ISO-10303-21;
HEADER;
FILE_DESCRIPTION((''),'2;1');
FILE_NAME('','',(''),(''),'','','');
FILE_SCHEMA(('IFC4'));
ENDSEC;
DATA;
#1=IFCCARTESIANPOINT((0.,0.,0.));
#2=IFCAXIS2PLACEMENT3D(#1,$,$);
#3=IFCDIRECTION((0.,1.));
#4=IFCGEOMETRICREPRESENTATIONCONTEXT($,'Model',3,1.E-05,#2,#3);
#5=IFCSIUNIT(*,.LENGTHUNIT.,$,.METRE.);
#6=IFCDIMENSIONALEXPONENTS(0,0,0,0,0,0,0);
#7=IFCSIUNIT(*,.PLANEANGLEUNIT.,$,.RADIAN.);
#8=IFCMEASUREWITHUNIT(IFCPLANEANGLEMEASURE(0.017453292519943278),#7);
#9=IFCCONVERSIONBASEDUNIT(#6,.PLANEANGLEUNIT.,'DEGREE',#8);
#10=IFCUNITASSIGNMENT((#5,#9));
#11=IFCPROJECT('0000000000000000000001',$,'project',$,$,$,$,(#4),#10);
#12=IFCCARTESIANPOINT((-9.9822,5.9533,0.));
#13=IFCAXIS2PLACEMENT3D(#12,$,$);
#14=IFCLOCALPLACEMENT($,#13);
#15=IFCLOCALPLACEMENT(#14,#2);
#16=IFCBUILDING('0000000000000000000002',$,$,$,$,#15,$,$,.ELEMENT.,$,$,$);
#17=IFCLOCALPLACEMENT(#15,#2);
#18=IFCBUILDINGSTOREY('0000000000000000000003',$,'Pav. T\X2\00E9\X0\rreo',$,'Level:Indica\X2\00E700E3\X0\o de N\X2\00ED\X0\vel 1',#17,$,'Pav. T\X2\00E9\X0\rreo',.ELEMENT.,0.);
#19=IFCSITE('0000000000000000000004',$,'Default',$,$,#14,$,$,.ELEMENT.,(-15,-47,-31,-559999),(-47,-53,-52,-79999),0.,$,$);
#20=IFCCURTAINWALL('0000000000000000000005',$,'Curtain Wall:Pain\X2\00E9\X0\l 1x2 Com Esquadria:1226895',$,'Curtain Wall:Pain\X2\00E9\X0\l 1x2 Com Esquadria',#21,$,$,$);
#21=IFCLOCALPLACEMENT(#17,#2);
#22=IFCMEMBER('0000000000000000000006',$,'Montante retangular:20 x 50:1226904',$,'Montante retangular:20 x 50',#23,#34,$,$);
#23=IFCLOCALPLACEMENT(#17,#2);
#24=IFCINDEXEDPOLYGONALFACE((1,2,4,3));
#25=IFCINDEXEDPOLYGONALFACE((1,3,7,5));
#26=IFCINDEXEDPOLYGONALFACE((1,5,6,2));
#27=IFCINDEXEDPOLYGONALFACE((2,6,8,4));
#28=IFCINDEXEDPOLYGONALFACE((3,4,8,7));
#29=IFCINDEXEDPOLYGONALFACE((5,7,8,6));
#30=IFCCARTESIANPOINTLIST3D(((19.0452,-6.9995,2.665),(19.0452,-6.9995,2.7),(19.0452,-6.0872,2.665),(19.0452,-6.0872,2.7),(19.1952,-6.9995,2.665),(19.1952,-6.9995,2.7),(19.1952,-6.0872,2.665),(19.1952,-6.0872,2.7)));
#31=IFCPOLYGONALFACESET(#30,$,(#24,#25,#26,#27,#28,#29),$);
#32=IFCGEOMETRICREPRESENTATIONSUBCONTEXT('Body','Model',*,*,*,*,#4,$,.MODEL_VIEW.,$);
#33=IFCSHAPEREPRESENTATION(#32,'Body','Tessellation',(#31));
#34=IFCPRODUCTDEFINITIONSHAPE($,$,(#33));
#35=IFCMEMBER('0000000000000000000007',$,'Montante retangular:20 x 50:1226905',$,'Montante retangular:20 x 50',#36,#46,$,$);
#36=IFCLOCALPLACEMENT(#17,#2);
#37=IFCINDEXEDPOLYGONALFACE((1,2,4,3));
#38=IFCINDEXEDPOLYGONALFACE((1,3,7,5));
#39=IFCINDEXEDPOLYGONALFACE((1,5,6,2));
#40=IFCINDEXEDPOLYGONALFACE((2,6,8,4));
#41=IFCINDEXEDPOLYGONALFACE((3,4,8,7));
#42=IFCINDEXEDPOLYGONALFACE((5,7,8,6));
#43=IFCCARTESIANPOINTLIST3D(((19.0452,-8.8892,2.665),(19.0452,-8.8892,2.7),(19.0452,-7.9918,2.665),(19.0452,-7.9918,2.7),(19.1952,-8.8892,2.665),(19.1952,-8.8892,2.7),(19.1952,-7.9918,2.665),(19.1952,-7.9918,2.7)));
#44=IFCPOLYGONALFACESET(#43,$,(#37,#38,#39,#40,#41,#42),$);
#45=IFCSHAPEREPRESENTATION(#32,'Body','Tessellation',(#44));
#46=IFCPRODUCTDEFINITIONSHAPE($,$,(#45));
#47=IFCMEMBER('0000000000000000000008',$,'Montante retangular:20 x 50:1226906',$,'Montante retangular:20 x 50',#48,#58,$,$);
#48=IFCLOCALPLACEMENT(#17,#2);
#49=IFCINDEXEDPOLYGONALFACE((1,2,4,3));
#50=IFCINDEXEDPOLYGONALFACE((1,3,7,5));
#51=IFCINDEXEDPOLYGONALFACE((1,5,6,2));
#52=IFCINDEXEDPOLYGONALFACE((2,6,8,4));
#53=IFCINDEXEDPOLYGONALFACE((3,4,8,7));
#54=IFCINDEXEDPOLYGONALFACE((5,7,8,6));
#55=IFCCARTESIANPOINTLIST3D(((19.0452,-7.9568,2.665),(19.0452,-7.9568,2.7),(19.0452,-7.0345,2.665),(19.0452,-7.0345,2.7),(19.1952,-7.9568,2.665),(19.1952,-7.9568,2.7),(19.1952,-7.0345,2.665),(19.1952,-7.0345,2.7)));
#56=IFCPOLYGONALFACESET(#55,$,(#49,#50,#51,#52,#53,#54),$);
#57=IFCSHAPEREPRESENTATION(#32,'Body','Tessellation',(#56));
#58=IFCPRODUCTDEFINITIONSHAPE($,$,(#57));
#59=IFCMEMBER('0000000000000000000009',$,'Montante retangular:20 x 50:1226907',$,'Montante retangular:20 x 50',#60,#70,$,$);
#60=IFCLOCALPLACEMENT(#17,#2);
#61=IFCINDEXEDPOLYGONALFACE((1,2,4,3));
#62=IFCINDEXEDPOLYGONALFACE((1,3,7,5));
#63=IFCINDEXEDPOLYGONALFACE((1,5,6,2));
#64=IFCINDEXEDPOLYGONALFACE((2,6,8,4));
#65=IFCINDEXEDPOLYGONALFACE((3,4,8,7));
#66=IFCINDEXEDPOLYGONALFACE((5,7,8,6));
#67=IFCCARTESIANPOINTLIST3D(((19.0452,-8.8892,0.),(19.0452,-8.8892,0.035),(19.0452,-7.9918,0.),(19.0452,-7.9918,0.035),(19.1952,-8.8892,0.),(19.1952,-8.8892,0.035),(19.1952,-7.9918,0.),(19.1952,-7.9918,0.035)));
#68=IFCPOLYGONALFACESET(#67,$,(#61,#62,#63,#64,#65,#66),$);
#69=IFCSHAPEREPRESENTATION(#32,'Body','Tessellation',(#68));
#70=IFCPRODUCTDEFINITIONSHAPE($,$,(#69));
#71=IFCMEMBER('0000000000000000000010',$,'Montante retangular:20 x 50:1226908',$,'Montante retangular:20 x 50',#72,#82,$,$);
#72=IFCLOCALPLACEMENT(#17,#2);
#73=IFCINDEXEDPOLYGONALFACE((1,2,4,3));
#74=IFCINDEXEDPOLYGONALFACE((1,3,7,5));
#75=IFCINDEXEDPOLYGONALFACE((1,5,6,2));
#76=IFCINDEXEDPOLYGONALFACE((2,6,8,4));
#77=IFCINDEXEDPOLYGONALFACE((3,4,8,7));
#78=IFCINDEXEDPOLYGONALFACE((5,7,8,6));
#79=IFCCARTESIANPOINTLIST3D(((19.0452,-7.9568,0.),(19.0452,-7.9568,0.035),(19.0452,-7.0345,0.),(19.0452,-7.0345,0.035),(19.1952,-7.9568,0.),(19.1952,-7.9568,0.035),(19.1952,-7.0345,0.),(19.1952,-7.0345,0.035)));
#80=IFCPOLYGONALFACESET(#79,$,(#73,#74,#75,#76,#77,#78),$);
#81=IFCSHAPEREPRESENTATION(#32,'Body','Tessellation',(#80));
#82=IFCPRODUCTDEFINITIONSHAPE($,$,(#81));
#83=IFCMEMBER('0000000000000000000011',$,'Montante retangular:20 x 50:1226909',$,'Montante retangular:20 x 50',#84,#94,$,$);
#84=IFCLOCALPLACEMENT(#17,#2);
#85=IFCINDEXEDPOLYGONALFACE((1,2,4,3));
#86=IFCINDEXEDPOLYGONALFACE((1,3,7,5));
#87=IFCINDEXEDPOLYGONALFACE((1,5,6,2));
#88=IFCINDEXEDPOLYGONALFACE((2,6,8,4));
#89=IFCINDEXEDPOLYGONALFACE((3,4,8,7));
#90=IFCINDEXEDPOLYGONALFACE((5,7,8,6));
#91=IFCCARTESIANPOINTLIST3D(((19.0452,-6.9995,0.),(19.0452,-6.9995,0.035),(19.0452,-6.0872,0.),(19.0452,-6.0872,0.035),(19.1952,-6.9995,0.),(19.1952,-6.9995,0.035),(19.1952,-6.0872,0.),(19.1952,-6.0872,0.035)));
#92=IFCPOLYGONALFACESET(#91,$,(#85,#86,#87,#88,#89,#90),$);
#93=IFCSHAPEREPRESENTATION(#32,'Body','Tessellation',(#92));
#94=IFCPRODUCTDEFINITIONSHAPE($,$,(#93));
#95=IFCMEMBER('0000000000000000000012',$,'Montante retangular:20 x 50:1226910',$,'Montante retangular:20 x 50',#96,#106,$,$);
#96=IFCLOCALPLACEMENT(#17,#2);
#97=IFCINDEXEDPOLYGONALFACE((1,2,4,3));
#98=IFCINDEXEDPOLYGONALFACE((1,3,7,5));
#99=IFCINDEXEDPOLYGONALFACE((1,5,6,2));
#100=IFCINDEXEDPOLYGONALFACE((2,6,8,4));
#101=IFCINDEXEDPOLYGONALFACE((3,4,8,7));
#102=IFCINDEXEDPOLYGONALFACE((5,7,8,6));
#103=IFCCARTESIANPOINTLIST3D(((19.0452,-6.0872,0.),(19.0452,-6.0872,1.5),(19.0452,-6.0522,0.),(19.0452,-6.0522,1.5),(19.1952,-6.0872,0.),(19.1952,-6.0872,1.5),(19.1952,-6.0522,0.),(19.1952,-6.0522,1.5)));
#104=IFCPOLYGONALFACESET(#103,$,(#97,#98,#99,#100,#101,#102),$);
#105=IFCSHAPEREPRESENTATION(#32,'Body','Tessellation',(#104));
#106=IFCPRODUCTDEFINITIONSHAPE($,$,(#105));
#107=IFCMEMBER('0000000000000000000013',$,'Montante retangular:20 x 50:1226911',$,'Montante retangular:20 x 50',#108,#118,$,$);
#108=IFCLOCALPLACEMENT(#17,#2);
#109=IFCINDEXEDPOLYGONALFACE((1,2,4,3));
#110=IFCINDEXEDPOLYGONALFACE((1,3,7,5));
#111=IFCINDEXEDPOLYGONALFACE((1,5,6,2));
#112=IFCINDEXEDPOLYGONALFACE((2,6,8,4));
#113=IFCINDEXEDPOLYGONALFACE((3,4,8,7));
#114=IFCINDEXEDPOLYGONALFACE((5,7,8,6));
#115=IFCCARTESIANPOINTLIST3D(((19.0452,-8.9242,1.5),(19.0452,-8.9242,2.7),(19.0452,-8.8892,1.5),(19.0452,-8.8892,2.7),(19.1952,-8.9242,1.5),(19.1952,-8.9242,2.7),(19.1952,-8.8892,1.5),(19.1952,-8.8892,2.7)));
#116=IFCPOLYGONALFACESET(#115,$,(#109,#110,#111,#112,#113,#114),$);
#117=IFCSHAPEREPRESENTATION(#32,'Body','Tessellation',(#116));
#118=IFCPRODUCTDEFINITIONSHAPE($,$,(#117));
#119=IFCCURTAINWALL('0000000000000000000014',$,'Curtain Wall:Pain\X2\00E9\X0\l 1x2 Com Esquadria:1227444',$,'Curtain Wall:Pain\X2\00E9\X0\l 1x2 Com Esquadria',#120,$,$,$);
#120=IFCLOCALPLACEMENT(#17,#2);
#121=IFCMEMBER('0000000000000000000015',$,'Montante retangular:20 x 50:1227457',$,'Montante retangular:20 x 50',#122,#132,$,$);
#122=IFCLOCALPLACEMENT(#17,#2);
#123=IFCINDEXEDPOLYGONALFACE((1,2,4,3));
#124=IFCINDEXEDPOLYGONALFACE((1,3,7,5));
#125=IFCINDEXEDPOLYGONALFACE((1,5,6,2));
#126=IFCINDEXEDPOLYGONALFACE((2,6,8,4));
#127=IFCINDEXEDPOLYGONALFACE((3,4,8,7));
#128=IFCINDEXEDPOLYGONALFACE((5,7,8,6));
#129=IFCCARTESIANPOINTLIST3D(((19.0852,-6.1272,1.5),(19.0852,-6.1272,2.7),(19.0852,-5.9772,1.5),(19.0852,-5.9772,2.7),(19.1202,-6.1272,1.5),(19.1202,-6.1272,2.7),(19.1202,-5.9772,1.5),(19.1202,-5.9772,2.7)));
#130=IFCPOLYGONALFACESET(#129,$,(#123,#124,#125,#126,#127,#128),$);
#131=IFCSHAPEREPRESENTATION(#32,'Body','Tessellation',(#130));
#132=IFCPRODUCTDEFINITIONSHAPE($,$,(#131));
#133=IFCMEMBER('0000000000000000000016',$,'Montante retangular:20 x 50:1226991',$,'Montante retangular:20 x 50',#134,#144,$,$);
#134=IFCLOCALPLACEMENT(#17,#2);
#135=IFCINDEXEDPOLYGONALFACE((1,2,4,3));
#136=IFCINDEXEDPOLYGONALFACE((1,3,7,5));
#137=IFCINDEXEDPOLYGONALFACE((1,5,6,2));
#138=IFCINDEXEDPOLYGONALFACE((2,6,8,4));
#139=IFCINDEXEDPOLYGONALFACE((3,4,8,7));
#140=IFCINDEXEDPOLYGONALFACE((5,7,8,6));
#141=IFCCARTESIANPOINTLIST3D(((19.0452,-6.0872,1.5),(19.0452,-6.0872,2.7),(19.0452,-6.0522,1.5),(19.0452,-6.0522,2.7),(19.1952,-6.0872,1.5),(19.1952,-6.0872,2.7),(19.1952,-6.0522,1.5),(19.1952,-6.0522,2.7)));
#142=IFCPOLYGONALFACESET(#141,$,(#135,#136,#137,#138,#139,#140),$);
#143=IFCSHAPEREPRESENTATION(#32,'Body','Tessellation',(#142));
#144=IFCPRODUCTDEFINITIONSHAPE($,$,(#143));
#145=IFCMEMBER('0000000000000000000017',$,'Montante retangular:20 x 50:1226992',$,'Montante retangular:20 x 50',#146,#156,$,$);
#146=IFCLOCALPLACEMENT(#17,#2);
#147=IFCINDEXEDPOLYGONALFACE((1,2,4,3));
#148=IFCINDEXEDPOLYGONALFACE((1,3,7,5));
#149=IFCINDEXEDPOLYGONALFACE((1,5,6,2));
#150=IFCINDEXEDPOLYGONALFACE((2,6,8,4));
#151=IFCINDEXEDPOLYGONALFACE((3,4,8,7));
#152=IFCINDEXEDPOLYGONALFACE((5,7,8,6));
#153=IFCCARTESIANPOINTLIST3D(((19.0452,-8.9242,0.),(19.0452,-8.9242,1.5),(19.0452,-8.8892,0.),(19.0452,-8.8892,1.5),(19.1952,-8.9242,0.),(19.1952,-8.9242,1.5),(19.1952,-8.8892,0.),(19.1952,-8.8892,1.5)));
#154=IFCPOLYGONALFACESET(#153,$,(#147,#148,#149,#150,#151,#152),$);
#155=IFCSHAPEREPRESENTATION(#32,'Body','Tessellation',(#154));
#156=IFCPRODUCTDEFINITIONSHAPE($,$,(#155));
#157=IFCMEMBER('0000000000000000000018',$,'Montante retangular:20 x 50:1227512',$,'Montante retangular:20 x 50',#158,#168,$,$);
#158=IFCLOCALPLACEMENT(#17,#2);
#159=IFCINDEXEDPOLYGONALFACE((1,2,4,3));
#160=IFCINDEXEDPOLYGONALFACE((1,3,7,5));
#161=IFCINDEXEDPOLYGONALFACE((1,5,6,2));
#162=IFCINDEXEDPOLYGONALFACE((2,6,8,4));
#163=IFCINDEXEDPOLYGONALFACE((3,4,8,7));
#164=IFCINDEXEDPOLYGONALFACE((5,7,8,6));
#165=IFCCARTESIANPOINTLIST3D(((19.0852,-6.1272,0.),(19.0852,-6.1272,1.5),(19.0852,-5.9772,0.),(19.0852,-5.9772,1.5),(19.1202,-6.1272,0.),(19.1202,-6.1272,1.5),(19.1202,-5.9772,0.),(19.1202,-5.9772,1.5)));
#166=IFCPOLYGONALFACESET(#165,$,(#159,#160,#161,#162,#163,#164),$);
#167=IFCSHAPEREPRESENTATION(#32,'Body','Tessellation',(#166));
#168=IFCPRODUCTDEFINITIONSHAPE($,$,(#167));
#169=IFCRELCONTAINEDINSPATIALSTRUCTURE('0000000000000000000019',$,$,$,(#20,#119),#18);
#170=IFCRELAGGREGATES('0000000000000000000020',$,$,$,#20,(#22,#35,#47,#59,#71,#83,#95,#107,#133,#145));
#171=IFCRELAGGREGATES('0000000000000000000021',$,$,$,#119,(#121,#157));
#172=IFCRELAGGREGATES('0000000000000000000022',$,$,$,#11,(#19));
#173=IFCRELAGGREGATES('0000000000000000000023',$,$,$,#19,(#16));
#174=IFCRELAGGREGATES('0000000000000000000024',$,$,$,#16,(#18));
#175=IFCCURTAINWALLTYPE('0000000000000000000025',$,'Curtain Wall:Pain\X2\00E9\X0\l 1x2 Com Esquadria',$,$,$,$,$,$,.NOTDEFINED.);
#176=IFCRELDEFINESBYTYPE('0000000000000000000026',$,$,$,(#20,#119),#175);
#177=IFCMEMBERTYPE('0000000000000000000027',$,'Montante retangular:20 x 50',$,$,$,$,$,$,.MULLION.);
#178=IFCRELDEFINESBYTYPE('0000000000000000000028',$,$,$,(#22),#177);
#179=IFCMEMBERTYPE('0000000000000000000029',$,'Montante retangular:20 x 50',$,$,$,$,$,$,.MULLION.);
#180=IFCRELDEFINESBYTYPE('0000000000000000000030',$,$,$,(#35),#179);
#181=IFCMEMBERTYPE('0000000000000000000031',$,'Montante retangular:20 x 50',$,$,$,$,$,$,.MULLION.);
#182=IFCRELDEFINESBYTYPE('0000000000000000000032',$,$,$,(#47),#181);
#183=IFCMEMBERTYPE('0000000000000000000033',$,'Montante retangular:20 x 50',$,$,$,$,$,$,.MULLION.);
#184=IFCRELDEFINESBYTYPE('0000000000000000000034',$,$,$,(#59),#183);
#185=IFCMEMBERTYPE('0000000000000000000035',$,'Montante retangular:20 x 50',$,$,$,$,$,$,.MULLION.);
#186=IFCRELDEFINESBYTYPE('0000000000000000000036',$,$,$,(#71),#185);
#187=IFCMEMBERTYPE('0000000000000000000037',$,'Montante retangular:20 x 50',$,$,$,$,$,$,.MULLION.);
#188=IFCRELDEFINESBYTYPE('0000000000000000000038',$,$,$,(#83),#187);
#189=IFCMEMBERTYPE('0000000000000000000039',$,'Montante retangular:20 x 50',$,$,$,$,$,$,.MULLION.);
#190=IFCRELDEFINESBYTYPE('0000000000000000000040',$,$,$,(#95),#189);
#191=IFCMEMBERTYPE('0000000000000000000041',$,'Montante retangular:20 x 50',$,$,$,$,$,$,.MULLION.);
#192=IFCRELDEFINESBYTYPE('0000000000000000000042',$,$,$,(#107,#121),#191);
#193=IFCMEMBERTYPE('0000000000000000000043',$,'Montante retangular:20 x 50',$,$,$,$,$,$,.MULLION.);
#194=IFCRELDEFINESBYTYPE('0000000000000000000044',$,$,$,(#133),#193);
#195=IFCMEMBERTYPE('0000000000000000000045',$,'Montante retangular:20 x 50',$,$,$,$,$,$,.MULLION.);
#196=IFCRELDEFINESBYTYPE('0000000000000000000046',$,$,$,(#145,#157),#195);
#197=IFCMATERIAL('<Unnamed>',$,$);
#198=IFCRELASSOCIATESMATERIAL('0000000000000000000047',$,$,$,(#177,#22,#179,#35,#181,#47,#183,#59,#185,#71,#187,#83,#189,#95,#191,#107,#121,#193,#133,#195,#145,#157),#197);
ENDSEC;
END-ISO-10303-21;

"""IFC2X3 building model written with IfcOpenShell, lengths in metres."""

from ifc_helpers import new_model, entity, si_unit, converted_unit, direction, frame, origin, origin_2d_with_axis, place, context, subcontext, project, spatial, rectangle, extrude, source, transform, mapped, material, type_object, type_shapes, element, aggregate, save


model = new_model("IFC2X3")

# Units and contexts
model_context = context("Model", 3, precision=1e-05, world=origin(), true_north=direction((0.0, 1.0)))
body_context = subcontext(model_context, "Body", "Model", "MODEL_VIEW")
ifc_project = project(units=[si_unit("LENGTHUNIT", "METRE"), converted_unit("PLANEANGLEUNIT", "DEGREE", entity("IfcPlaneAngleMeasure", 0.017453292519943278), si_unit("PLANEANGLEUNIT", "RADIAN"), dimensions=[0, 0, 0, 0, 0, 0, 0])], contexts=[model_context])

# Site, building, storey
site_placement = place(None, frame((-9.9822, 5.9533, 0.0)))
site = spatial("IfcSite", under=ifc_project, at=site_placement, Name="Default", CompositionType="ELEMENT", RefLatitude=(-15, -47, -31, -559999), RefLongitude=(-47, -53, -52, -79999), RefElevation=0.0)
building_placement = place(site_placement, origin())
building = spatial("IfcBuilding", under=site, at=building_placement, CompositionType="ELEMENT")
storey_placement = place(building_placement, origin())
storey = spatial("IfcBuildingStorey", under=building, at=storey_placement, Name="Pav. Térreo", ObjectType="Level:Indicação de Nível 1", LongName="Pav. Térreo", CompositionType="ELEMENT", Elevation=0.0)

# Curtain wall, members
curtain_wall_type = type_object("IfcCurtainWallType", Name="Curtain Wall:Painél 1x2 Com Esquadria", PredefinedType="NOTDEFINED")
curtain_wall_1_placement = place(storey_placement, origin())
curtain_wall_1 = element("IfcCurtainWall", 1, at=curtain_wall_1_placement, inside=storey, type_object=curtain_wall_type, Name="Curtain Wall:Painél 1x2 Com Esquadria:1226895", ObjectType="Curtain Wall:Painél 1x2 Com Esquadria")
ifc_material_1 = material(Name="<Unnamed>")
member_type_1 = type_object("IfcMemberType", Name="Montante retangular:20 x 50", PredefinedType="MULLION", material=ifc_material_1)
shared_shape_1 = source(origin(), body_context, "Body", "SweptSolid", [
    extrude(rectangle(XDim=0.035, YDim=0.15, at=origin_2d_with_axis()), frame((-0.0175, 0.0, -0.9123), z_axis=(0.0, 0.0, 1.0), x_axis=(-1.0, 0.0, 0.0)), (0.0, 0.0, 1.0), 0.9123),
])
type_shapes(member_type_1, [shared_shape_1])
member_1_placement = place(curtain_wall_1_placement, frame((19.1202, -6.0872, 2.7), z_axis=(0.0, 1.0, 0.0), x_axis=(0.0, 0.0, 1.0)))
member_1 = element("IfcMember", 2, at=member_1_placement, type_object=member_type_1, material=ifc_material_1, Name="Montante retangular:20 x 50:1226904", ObjectType="Montante retangular:20 x 50", context=body_context, shape_type="MappedRepresentation", body=[
    mapped(shared_shape_1, transform((0.0, 0.0, 0.0), scale=1.0)),
])
member_type_2 = type_object("IfcMemberType", Name="Montante retangular:20 x 50", PredefinedType="MULLION", material=ifc_material_1)
shared_shape_2 = source(origin(), body_context, "Body", "SweptSolid", [
    extrude(rectangle(XDim=0.035, YDim=0.15, at=origin_2d_with_axis()), frame((-0.0175, 0.0, -0.8973), z_axis=(0.0, 0.0, 1.0), x_axis=(-1.0, 0.0, 0.0)), (0.0, 0.0, 1.0), 0.8973),
])
type_shapes(member_type_2, [shared_shape_2])
member_2_placement = place(curtain_wall_1_placement, frame((19.1202, -7.9918, 2.7), z_axis=(0.0, 1.0, 0.0), x_axis=(0.0, 0.0, 1.0)))
member_2 = element("IfcMember", 3, at=member_2_placement, type_object=member_type_2, material=ifc_material_1, Name="Montante retangular:20 x 50:1226905", ObjectType="Montante retangular:20 x 50", context=body_context, shape_type="MappedRepresentation", body=[
    mapped(shared_shape_2, transform((0.0, 0.0, 0.0), scale=1.0)),
])
member_type_3 = type_object("IfcMemberType", Name="Montante retangular:20 x 50", PredefinedType="MULLION", material=ifc_material_1)
shared_shape_3 = source(origin(), body_context, "Body", "SweptSolid", [
    extrude(rectangle(XDim=0.035, YDim=0.15, at=origin_2d_with_axis()), frame((-0.0175, 0.0, -0.9223), z_axis=(0.0, 0.0, 1.0), x_axis=(-1.0, 0.0, 0.0)), (0.0, 0.0, 1.0), 0.9223),
])
type_shapes(member_type_3, [shared_shape_3])
member_3_placement = place(curtain_wall_1_placement, frame((19.1202, -7.0345, 2.7), z_axis=(0.0, 1.0, 0.0), x_axis=(0.0, 0.0, 1.0)))
member_3 = element("IfcMember", 4, at=member_3_placement, type_object=member_type_3, material=ifc_material_1, Name="Montante retangular:20 x 50:1226906", ObjectType="Montante retangular:20 x 50", context=body_context, shape_type="MappedRepresentation", body=[
    mapped(shared_shape_3, transform((0.0, 0.0, 0.0), scale=1.0)),
])
member_type_4 = type_object("IfcMemberType", Name="Montante retangular:20 x 50", PredefinedType="MULLION", material=ifc_material_1)
shared_shape_4 = source(origin(), body_context, "Body", "SweptSolid", [
    extrude(rectangle(XDim=0.035, YDim=0.15, at=origin_2d_with_axis()), frame((-0.0175, 0.0, -0.8973), z_axis=(0.0, 0.0, 1.0), x_axis=(-1.0, 0.0, 0.0)), (0.0, 0.0, 1.0), 0.8973),
])
type_shapes(member_type_4, [shared_shape_4])
member_4_placement = place(curtain_wall_1_placement, frame((19.1202, -8.8892, 0.0), z_axis=(0.0, -1.0, 0.0), x_axis=(0.0, 0.0, -1.0)))
member_4 = element("IfcMember", 5, at=member_4_placement, type_object=member_type_4, material=ifc_material_1, Name="Montante retangular:20 x 50:1226907", ObjectType="Montante retangular:20 x 50", context=body_context, shape_type="MappedRepresentation", body=[
    mapped(shared_shape_4, transform((0.0, 0.0, 0.0), scale=1.0)),
])
member_type_5 = type_object("IfcMemberType", Name="Montante retangular:20 x 50", PredefinedType="MULLION", material=ifc_material_1)
shared_shape_5 = source(origin(), body_context, "Body", "SweptSolid", [
    extrude(rectangle(XDim=0.035, YDim=0.15, at=origin_2d_with_axis()), frame((-0.0175, 0.0, -0.9223), z_axis=(0.0, 0.0, 1.0), x_axis=(-1.0, 0.0, 0.0)), (0.0, 0.0, 1.0), 0.9223),
])
type_shapes(member_type_5, [shared_shape_5])
member_5_placement = place(curtain_wall_1_placement, frame((19.1202, -7.9568, 0.0), z_axis=(0.0, -1.0, 0.0), x_axis=(0.0, 0.0, -1.0)))
member_5 = element("IfcMember", 6, at=member_5_placement, type_object=member_type_5, material=ifc_material_1, Name="Montante retangular:20 x 50:1226908", ObjectType="Montante retangular:20 x 50", context=body_context, shape_type="MappedRepresentation", body=[
    mapped(shared_shape_5, transform((0.0, 0.0, 0.0), scale=1.0)),
])
member_type_6 = type_object("IfcMemberType", Name="Montante retangular:20 x 50", PredefinedType="MULLION", material=ifc_material_1)
shared_shape_6 = source(origin(), body_context, "Body", "SweptSolid", [
    extrude(rectangle(XDim=0.035, YDim=0.15, at=origin_2d_with_axis()), frame((-0.0175, 0.0, -0.9123), z_axis=(0.0, 0.0, 1.0), x_axis=(-1.0, 0.0, 0.0)), (0.0, 0.0, 1.0), 0.9123),
])
type_shapes(member_type_6, [shared_shape_6])
member_6_placement = place(curtain_wall_1_placement, frame((19.1202, -6.9995, 0.0), z_axis=(0.0, -1.0, 0.0), x_axis=(0.0, 0.0, -1.0)))
member_6 = element("IfcMember", 7, at=member_6_placement, type_object=member_type_6, material=ifc_material_1, Name="Montante retangular:20 x 50:1226909", ObjectType="Montante retangular:20 x 50", context=body_context, shape_type="MappedRepresentation", body=[
    mapped(shared_shape_6, transform((0.0, 0.0, 0.0), scale=1.0)),
])
member_type_7 = type_object("IfcMemberType", Name="Montante retangular:20 x 50", PredefinedType="MULLION", material=ifc_material_1)
shared_shape_7 = source(origin(), body_context, "Body", "SweptSolid", [
    extrude(rectangle(XDim=0.035, YDim=0.15, at=origin_2d_with_axis()), frame((-0.0175, 0.0, -1.5), z_axis=(0.0, 0.0, 1.0), x_axis=(-1.0, 0.0, 0.0)), (0.0, 0.0, 1.0), 1.5),
])
type_shapes(member_type_7, [shared_shape_7])
member_7_placement = place(curtain_wall_1_placement, frame((19.1202, -6.0522, 0.0), z_axis=(0.0, 0.0, -1.0), x_axis=(0.0, 1.0, 0.0)))
member_7 = element("IfcMember", 8, at=member_7_placement, type_object=member_type_7, material=ifc_material_1, Name="Montante retangular:20 x 50:1226910", ObjectType="Montante retangular:20 x 50", context=body_context, shape_type="MappedRepresentation", body=[
    mapped(shared_shape_7, transform((0.0, 0.0, 0.0), scale=1.0)),
])
member_type_8 = type_object("IfcMemberType", Name="Montante retangular:20 x 50", PredefinedType="MULLION", material=ifc_material_1)
shared_shape_8 = source(origin(), body_context, "Body", "SweptSolid", [
    extrude(rectangle(XDim=0.035, YDim=0.15, at=origin_2d_with_axis()), frame((-0.0175, 0.0, -1.2), z_axis=(0.0, 0.0, 1.0), x_axis=(-1.0, 0.0, 0.0)), (0.0, 0.0, 1.0), 1.2),
])
type_shapes(member_type_8, [shared_shape_8])
member_8_placement = place(curtain_wall_1_placement, frame((19.1202, -8.9242, 2.7), z_axis=(0.0, 0.0, 1.0), x_axis=(0.0, -1.0, 0.0)))
member_8 = element("IfcMember", 9, at=member_8_placement, type_object=member_type_8, material=ifc_material_1, Name="Montante retangular:20 x 50:1226911", ObjectType="Montante retangular:20 x 50", context=body_context, shape_type="MappedRepresentation", body=[
    mapped(shared_shape_8, transform((0.0, 0.0, 0.0), scale=1.0)),
])

# Curtain wall, member
curtain_wall_2_placement = place(storey_placement, origin())
curtain_wall_2 = element("IfcCurtainWall", 10, at=curtain_wall_2_placement, inside=storey, type_object=curtain_wall_type, Name="Curtain Wall:Painél 1x2 Com Esquadria:1227444", ObjectType="Curtain Wall:Painél 1x2 Com Esquadria")
member_9_placement = place(curtain_wall_2_placement, frame((19.1202, -6.0522, 2.7)))
member_9 = element("IfcMember", 11, at=member_9_placement, type_object=member_type_8, material=ifc_material_1, Name="Montante retangular:20 x 50:1227457", ObjectType="Montante retangular:20 x 50", context=body_context, shape_type="MappedRepresentation", body=[
    mapped(shared_shape_8, transform((0.0, 0.0, 0.0), scale=1.0)),
])

# Members
member_type_9 = type_object("IfcMemberType", Name="Montante retangular:20 x 50", PredefinedType="MULLION", material=ifc_material_1)
shared_shape_9 = source(origin(), body_context, "Body", "SweptSolid", [
    extrude(rectangle(XDim=0.035, YDim=0.15, at=origin_2d_with_axis()), frame((-0.0175, 0.0, -1.2), z_axis=(0.0, 0.0, 1.0), x_axis=(-1.0, 0.0, 0.0)), (0.0, 0.0, 1.0), 1.2),
])
type_shapes(member_type_9, [shared_shape_9])
member_10_placement = place(curtain_wall_1_placement, frame((19.1202, -6.0522, 1.5), z_axis=(0.0, 0.0, -1.0), x_axis=(0.0, 1.0, 0.0)))
member_10 = element("IfcMember", 12, at=member_10_placement, type_object=member_type_9, material=ifc_material_1, Name="Montante retangular:20 x 50:1226991", ObjectType="Montante retangular:20 x 50", context=body_context, shape_type="MappedRepresentation", body=[
    mapped(shared_shape_9, transform((0.0, 0.0, 0.0), scale=1.0)),
])
member_type_10 = type_object("IfcMemberType", Name="Montante retangular:20 x 50", PredefinedType="MULLION", material=ifc_material_1)
shared_shape_10 = source(origin(), body_context, "Body", "SweptSolid", [
    extrude(rectangle(XDim=0.035, YDim=0.15, at=origin_2d_with_axis()), frame((-0.0175, 0.0, -1.5), z_axis=(0.0, 0.0, 1.0), x_axis=(-1.0, 0.0, 0.0)), (0.0, 0.0, 1.0), 1.5),
])
type_shapes(member_type_10, [shared_shape_10])
member_11_placement = place(curtain_wall_1_placement, frame((19.1202, -8.9242, 1.5), z_axis=(0.0, 0.0, 1.0), x_axis=(0.0, -1.0, 0.0)))
member_11 = element("IfcMember", 13, at=member_11_placement, type_object=member_type_10, material=ifc_material_1, Name="Montante retangular:20 x 50:1226992", ObjectType="Montante retangular:20 x 50", context=body_context, shape_type="MappedRepresentation", body=[
    mapped(shared_shape_10, transform((0.0, 0.0, 0.0), scale=1.0)),
])
member_12_placement = place(curtain_wall_2_placement, frame((19.1202, -6.0522, 1.5)))
member_12 = element("IfcMember", 14, at=member_12_placement, type_object=member_type_10, material=ifc_material_1, Name="Montante retangular:20 x 50:1227512", ObjectType="Montante retangular:20 x 50", context=body_context, shape_type="MappedRepresentation", body=[
    mapped(shared_shape_10, transform((0.0, 0.0, 0.0), scale=1.0)),
])

aggregate(curtain_wall_1, [member_1, member_2, member_3, member_4, member_5, member_6, member_7, member_8, member_10, member_11])
aggregate(curtain_wall_2, [member_9, member_12])

save(model, "model.ifc")
